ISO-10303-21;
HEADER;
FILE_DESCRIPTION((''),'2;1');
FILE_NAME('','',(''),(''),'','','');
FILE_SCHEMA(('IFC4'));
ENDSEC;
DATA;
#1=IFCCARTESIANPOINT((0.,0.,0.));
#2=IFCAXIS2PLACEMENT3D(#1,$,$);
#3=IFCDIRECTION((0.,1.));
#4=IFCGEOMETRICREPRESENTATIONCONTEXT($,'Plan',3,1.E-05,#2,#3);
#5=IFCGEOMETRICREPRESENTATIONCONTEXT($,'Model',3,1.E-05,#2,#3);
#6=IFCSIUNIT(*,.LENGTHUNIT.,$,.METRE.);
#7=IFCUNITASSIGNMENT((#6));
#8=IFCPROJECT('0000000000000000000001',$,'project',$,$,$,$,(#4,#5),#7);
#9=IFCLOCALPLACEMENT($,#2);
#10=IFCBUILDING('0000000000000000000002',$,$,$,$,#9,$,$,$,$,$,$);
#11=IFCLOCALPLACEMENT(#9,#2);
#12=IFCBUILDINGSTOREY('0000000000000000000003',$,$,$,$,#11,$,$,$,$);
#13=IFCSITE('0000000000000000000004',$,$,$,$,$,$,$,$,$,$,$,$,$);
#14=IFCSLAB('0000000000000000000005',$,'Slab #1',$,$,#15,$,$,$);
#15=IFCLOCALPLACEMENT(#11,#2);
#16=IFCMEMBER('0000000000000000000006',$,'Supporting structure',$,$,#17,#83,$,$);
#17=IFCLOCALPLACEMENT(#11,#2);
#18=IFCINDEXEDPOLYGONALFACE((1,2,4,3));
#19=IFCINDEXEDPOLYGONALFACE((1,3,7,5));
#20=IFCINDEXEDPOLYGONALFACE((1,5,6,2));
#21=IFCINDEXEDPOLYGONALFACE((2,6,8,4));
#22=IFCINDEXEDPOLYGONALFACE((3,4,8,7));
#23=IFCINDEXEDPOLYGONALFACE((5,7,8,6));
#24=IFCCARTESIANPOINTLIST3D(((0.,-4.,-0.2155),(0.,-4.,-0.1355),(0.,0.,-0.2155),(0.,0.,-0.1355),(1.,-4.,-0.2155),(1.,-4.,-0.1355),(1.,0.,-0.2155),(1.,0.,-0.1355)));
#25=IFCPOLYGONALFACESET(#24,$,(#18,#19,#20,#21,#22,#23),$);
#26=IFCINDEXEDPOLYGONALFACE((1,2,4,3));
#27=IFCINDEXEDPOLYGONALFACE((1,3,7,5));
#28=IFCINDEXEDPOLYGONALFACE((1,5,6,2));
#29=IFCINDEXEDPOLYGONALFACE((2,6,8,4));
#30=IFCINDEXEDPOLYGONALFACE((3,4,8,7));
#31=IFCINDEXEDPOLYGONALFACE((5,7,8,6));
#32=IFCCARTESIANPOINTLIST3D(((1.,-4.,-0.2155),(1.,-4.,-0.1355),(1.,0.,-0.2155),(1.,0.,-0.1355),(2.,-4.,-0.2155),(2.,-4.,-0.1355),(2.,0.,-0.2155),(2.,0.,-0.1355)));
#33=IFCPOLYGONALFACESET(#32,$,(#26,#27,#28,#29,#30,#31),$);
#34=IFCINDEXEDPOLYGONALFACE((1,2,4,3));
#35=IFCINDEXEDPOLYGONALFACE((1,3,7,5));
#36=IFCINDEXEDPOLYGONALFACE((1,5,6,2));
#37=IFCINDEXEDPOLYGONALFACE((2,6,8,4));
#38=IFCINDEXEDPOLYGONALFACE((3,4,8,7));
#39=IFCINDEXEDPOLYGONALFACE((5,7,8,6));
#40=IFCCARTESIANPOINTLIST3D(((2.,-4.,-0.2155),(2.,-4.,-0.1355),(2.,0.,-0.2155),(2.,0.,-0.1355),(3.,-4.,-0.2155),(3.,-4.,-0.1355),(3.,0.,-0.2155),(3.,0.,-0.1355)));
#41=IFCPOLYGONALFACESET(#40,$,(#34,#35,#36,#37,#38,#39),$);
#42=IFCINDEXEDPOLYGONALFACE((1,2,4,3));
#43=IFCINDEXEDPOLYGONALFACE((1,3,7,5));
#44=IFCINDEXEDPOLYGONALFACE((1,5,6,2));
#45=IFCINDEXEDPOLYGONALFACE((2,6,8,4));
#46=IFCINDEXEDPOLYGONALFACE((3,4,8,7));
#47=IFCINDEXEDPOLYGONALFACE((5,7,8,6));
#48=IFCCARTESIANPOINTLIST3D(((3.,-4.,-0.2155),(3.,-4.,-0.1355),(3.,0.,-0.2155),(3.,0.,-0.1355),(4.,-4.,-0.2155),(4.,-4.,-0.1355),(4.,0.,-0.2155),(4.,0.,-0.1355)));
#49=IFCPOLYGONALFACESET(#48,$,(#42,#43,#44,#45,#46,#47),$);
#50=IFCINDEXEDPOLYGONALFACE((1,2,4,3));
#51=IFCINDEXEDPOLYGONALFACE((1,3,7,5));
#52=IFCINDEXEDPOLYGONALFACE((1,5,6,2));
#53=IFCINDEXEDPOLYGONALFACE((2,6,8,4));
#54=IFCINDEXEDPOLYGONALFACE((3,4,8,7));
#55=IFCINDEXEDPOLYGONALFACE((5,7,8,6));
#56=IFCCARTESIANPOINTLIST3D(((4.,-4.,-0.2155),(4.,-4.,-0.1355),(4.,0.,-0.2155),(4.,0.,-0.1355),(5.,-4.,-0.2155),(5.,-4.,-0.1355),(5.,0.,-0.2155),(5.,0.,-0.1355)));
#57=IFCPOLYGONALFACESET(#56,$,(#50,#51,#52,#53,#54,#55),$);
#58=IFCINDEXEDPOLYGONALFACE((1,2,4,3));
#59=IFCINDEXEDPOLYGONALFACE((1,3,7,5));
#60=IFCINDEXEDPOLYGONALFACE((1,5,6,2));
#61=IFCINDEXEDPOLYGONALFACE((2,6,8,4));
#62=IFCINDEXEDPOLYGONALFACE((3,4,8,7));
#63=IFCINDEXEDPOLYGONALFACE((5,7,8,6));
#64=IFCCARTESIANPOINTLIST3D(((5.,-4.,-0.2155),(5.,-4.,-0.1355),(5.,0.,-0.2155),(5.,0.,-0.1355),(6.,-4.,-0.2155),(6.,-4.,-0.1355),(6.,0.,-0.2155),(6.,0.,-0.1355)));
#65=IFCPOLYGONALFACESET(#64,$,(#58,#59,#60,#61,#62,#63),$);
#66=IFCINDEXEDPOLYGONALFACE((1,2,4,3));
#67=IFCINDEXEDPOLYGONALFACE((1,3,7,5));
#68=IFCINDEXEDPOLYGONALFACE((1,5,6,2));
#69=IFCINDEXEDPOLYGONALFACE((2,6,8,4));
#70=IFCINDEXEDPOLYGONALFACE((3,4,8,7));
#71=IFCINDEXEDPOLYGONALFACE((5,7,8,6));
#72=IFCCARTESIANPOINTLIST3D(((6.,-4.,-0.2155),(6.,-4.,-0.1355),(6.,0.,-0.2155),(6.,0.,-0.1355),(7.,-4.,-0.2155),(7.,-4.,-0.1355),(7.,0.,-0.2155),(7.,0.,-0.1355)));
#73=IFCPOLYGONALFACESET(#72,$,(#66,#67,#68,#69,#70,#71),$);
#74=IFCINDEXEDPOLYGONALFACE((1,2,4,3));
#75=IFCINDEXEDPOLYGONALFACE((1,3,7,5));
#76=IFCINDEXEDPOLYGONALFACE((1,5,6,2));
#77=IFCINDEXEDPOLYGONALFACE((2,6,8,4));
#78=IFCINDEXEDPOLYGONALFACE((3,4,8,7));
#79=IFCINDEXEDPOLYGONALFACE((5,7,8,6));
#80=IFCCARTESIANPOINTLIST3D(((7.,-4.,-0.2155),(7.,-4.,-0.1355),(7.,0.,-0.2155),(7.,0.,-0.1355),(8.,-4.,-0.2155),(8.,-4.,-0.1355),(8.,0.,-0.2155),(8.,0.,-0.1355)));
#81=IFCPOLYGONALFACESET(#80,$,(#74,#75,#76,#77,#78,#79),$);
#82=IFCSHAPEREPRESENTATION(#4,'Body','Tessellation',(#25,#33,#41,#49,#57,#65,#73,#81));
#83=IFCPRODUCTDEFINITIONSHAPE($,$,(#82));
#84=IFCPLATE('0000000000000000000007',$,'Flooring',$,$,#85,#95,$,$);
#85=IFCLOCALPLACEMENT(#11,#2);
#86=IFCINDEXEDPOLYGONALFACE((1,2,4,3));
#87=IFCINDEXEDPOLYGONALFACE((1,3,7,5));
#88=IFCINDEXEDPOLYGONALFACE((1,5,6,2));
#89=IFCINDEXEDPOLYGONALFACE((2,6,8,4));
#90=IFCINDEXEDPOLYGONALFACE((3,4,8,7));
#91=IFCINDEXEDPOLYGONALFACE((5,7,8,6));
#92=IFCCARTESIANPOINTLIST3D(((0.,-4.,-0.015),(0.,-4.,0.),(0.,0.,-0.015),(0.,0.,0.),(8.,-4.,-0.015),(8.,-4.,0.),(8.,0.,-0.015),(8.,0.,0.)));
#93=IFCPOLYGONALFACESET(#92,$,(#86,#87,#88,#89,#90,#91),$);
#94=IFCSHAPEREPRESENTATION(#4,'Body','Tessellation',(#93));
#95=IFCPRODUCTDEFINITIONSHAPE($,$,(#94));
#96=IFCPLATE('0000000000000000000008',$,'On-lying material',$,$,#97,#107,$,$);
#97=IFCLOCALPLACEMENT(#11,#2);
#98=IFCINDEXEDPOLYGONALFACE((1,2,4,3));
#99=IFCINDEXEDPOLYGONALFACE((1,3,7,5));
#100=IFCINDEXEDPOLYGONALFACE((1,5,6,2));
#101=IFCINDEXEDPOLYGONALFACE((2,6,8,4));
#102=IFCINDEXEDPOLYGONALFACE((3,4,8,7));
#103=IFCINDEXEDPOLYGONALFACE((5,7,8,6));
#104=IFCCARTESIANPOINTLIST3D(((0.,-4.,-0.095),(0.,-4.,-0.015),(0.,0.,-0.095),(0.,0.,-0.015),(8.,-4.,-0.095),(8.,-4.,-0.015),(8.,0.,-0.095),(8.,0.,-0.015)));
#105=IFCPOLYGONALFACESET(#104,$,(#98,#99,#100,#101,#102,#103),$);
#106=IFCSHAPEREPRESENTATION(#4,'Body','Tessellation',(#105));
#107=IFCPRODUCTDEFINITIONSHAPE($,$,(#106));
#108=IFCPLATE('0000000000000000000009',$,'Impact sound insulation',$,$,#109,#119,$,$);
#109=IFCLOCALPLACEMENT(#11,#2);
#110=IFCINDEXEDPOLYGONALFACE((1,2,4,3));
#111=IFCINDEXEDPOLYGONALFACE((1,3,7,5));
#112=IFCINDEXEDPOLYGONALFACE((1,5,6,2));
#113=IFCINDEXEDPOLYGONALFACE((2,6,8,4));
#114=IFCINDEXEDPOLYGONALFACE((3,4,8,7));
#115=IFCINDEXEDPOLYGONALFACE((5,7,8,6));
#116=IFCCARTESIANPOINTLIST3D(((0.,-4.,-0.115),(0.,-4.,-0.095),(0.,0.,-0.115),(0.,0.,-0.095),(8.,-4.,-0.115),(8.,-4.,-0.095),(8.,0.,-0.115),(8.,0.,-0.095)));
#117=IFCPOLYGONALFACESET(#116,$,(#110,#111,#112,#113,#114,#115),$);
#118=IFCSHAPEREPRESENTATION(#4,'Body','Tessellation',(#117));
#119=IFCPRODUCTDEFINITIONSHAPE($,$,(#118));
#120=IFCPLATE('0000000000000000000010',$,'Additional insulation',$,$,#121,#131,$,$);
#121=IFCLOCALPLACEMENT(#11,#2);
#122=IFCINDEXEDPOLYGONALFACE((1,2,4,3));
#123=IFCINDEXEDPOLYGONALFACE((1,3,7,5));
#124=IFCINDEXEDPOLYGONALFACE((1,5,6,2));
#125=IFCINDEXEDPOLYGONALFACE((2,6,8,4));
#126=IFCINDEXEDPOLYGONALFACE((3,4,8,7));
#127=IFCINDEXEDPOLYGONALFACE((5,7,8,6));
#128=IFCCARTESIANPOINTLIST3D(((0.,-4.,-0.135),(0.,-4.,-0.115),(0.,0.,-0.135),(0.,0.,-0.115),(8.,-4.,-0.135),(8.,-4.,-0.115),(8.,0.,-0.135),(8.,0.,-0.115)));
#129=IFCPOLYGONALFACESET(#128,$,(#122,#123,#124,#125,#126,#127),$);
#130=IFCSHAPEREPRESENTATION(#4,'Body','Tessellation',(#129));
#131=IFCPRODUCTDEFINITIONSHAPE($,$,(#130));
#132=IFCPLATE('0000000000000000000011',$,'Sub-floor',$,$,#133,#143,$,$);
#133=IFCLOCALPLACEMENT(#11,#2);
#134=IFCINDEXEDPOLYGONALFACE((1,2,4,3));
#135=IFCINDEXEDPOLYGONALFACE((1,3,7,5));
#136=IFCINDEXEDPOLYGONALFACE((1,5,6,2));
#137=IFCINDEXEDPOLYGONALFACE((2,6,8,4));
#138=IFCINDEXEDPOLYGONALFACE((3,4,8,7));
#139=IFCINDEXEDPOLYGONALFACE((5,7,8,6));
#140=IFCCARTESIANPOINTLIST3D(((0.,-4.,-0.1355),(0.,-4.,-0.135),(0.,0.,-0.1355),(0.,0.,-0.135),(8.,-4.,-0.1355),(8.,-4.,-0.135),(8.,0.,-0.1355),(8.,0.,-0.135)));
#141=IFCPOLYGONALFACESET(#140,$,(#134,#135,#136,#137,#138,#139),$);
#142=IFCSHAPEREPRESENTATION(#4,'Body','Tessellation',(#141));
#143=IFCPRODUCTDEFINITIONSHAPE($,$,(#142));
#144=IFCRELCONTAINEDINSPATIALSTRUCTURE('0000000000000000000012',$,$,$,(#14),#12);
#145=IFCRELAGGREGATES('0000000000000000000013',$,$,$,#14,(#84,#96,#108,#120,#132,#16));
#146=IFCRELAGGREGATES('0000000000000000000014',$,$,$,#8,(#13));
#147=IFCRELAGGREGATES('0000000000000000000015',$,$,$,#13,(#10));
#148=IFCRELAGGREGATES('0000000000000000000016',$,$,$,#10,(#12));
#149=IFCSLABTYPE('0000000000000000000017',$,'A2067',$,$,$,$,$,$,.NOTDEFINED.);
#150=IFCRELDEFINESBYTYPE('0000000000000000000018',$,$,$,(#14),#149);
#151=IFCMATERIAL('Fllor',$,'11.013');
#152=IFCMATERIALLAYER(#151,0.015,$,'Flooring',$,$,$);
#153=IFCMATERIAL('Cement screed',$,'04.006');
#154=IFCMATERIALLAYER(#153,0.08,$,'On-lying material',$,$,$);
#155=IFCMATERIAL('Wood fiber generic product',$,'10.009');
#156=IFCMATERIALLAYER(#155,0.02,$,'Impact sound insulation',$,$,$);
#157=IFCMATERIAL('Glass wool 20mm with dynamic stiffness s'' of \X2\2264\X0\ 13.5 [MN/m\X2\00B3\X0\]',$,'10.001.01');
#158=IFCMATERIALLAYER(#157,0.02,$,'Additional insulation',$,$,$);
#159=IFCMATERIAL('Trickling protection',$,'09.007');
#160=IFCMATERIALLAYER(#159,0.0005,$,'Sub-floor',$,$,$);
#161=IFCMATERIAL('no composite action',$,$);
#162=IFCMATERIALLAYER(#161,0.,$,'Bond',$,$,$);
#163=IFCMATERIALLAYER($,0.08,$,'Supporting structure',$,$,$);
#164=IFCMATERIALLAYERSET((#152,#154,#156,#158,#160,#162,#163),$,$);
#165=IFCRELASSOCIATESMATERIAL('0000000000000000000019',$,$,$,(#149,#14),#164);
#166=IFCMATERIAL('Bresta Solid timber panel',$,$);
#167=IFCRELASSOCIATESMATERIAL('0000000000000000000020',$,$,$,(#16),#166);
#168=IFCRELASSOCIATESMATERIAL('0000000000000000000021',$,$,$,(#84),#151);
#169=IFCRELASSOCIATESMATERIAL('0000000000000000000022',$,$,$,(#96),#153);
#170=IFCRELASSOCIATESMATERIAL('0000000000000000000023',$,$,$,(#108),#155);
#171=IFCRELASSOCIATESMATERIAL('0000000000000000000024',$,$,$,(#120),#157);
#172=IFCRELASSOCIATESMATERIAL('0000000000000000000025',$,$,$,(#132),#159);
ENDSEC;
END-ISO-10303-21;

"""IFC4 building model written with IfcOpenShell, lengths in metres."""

from ifc_helpers import new_model, si_unit, direction, frame, frame_2d, origin, origin_with_axes, place, context, project, spatial, rectangle, extrude, material, layer, layer_set, type_object, element, aggregate, save


model = new_model("IFC4")

# Units and contexts
plan_context = context("Plan", 3, precision=1e-05, world=origin(), true_north=direction((0.0, 1.0)))
model_context = context("Model", 3, precision=1e-05, world=origin(), true_north=direction((0.0, 1.0)))
ifc_project = project(units=[si_unit("LENGTHUNIT", "METRE")], contexts=[plan_context, model_context])

# Site, building, storey
site = spatial("IfcSite", under=ifc_project)
building_placement = place(None, origin())
building = spatial("IfcBuilding", under=site, at=building_placement)
storey_placement = place(building_placement, origin())
storey = spatial("IfcBuildingStorey", under=building, at=storey_placement)

# Slab, member, plates
ifc_material_1 = material(Name="Fllor", Category="11.013")
ifc_layer_1 = layer(ifc_material_1, 0.015, Name="Flooring")
ifc_material_2 = material(Name="Cement screed", Category="04.006")
ifc_layer_2 = layer(ifc_material_2, 0.08, Name="On-lying material")
ifc_material_3 = material(Name="Wood fiber generic product", Category="10.009")
ifc_layer_3 = layer(ifc_material_3, 0.02, Name="Impact sound insulation")
ifc_material_4 = material(Name="Glass wool 20mm with dynamic stiffness s' of ≤ 13.5 [MN/m³]", Category="10.001.01")
ifc_layer_4 = layer(ifc_material_4, 0.02, Name="Additional insulation")
ifc_material_5 = material(Name="Trickling protection", Category="09.007")
ifc_layer_5 = layer(ifc_material_5, 0.0005, Name="Sub-floor")
ifc_material_6 = material(Name="no composite action")
ifc_layer_6 = layer(ifc_material_6, 0.0, Name="Bond")
ifc_layer_7 = layer(None, 0.08, Name="Supporting structure")
ifc_layer_set = layer_set([ifc_layer_1, ifc_layer_2, ifc_layer_3, ifc_layer_4, ifc_layer_5, ifc_layer_6, ifc_layer_7])
slab_type = type_object("IfcSlabType", Name="A2067", PredefinedType="NOTDEFINED", material=ifc_layer_set)
slab_placement = place(None, frame((0.0, 0.0, 0.0), z_axis=(0.0, 0.0, -1.0), x_axis=(1.0, 0.0, 0.0)))
slab = element("IfcSlab", 1, at=slab_placement, inside=storey, type_object=slab_type, material=ifc_layer_set, Name="Slab #1")
ifc_material_7 = material(Name="Bresta Solid timber panel")
member_placement = place(slab_placement, origin())
member = element("IfcMember", 2, at=member_placement, material=ifc_material_7, Name="Supporting structure", context=plan_context, shape_type="SweptSolid", body=[
    extrude(rectangle(XDim=1.0, YDim=0.08, at=frame_2d((0.5, 0.04), x_axis=(1.0, 0.0))), frame((0.0, 4.0, 0.1355), z_axis=(0.0, -1.0, 0.0), x_axis=(1.0, 0.0, 0.0)), (0.0, 0.0, 1.0), 4.0),
    extrude(rectangle(XDim=1.0, YDim=0.08, at=frame_2d((0.5, 0.04), x_axis=(1.0, 0.0))), frame((1.0, 4.0, 0.1355), z_axis=(0.0, -1.0, 0.0), x_axis=(1.0, 0.0, 0.0)), (0.0, 0.0, 1.0), 4.0),
    extrude(rectangle(XDim=1.0, YDim=0.08, at=frame_2d((0.5, 0.04), x_axis=(1.0, 0.0))), frame((2.0, 4.0, 0.1355), z_axis=(0.0, -1.0, 0.0), x_axis=(1.0, 0.0, 0.0)), (0.0, 0.0, 1.0), 4.0),
    extrude(rectangle(XDim=1.0, YDim=0.08, at=frame_2d((0.5, 0.04), x_axis=(1.0, 0.0))), frame((3.0, 4.0, 0.1355), z_axis=(0.0, -1.0, 0.0), x_axis=(1.0, 0.0, 0.0)), (0.0, 0.0, 1.0), 4.0),
    extrude(rectangle(XDim=1.0, YDim=0.08, at=frame_2d((0.5, 0.04), x_axis=(1.0, 0.0))), frame((4.0, 4.0, 0.1355), z_axis=(0.0, -1.0, 0.0), x_axis=(1.0, 0.0, 0.0)), (0.0, 0.0, 1.0), 4.0),
    extrude(rectangle(XDim=1.0, YDim=0.08, at=frame_2d((0.5, 0.04), x_axis=(1.0, 0.0))), frame((5.0, 4.0, 0.1355), z_axis=(0.0, -1.0, 0.0), x_axis=(1.0, 0.0, 0.0)), (0.0, 0.0, 1.0), 4.0),
    extrude(rectangle(XDim=1.0, YDim=0.08, at=frame_2d((0.5, 0.04), x_axis=(1.0, 0.0))), frame((6.0, 4.0, 0.1355), z_axis=(0.0, -1.0, 0.0), x_axis=(1.0, 0.0, 0.0)), (0.0, 0.0, 1.0), 4.0),
    extrude(rectangle(XDim=1.0, YDim=0.08, at=frame_2d((0.5, 0.04), x_axis=(1.0, 0.0))), frame((7.0, 4.0, 0.1355), z_axis=(0.0, -1.0, 0.0), x_axis=(1.0, 0.0, 0.0)), (0.0, 0.0, 1.0), 4.0),
])
plate_1_placement = place(slab_placement, origin())
plate_1 = element("IfcPlate", 3, at=plate_1_placement, material=ifc_material_1, Name="Flooring", context=plan_context, shape_type="SweptSolid", body=[
    extrude(rectangle(XDim=8.0, YDim=4.0, at=frame_2d((4.0, 2.0), x_axis=(1.0, 0.0))), origin_with_axes(), (0.0, 0.0, 1.0), 0.015),
])
plate_2_placement = place(slab_placement, origin())
plate_2 = element("IfcPlate", 4, at=plate_2_placement, material=ifc_material_2, Name="On-lying material", context=plan_context, shape_type="SweptSolid", body=[
    extrude(rectangle(XDim=8.0, YDim=4.0, at=frame_2d((4.0, 2.0), x_axis=(1.0, 0.0))), frame((0.0, 0.0, 0.015), z_axis=(0.0, 0.0, 1.0), x_axis=(1.0, 0.0, 0.0)), (0.0, 0.0, 1.0), 0.08),
])
plate_3_placement = place(slab_placement, origin())
plate_3 = element("IfcPlate", 5, at=plate_3_placement, material=ifc_material_3, Name="Impact sound insulation", context=plan_context, shape_type="SweptSolid", body=[
    extrude(rectangle(XDim=8.0, YDim=4.0, at=frame_2d((4.0, 2.0), x_axis=(1.0, 0.0))), frame((0.0, 0.0, 0.095), z_axis=(0.0, 0.0, 1.0), x_axis=(1.0, 0.0, 0.0)), (0.0, 0.0, 1.0), 0.02),
])
plate_4_placement = place(slab_placement, origin())
plate_4 = element("IfcPlate", 6, at=plate_4_placement, material=ifc_material_4, Name="Additional insulation", context=plan_context, shape_type="SweptSolid", body=[
    extrude(rectangle(XDim=8.0, YDim=4.0, at=frame_2d((4.0, 2.0), x_axis=(1.0, 0.0))), frame((0.0, 0.0, 0.115), z_axis=(0.0, 0.0, 1.0), x_axis=(1.0, 0.0, 0.0)), (0.0, 0.0, 1.0), 0.02),
])
plate_5_placement = place(slab_placement, origin())
plate_5 = element("IfcPlate", 7, at=plate_5_placement, material=ifc_material_5, Name="Sub-floor", context=plan_context, shape_type="SweptSolid", body=[
    extrude(rectangle(XDim=8.0, YDim=4.0, at=frame_2d((4.0, 2.0), x_axis=(1.0, 0.0))), frame((0.0, 0.0, 0.135), z_axis=(0.0, 0.0, 1.0), x_axis=(1.0, 0.0, 0.0)), (0.0, 0.0, 1.0), 0.0005),
])
aggregate(slab, [plate_1, plate_2, plate_3, plate_4, plate_5, member])

save(model, "model.ifc")
